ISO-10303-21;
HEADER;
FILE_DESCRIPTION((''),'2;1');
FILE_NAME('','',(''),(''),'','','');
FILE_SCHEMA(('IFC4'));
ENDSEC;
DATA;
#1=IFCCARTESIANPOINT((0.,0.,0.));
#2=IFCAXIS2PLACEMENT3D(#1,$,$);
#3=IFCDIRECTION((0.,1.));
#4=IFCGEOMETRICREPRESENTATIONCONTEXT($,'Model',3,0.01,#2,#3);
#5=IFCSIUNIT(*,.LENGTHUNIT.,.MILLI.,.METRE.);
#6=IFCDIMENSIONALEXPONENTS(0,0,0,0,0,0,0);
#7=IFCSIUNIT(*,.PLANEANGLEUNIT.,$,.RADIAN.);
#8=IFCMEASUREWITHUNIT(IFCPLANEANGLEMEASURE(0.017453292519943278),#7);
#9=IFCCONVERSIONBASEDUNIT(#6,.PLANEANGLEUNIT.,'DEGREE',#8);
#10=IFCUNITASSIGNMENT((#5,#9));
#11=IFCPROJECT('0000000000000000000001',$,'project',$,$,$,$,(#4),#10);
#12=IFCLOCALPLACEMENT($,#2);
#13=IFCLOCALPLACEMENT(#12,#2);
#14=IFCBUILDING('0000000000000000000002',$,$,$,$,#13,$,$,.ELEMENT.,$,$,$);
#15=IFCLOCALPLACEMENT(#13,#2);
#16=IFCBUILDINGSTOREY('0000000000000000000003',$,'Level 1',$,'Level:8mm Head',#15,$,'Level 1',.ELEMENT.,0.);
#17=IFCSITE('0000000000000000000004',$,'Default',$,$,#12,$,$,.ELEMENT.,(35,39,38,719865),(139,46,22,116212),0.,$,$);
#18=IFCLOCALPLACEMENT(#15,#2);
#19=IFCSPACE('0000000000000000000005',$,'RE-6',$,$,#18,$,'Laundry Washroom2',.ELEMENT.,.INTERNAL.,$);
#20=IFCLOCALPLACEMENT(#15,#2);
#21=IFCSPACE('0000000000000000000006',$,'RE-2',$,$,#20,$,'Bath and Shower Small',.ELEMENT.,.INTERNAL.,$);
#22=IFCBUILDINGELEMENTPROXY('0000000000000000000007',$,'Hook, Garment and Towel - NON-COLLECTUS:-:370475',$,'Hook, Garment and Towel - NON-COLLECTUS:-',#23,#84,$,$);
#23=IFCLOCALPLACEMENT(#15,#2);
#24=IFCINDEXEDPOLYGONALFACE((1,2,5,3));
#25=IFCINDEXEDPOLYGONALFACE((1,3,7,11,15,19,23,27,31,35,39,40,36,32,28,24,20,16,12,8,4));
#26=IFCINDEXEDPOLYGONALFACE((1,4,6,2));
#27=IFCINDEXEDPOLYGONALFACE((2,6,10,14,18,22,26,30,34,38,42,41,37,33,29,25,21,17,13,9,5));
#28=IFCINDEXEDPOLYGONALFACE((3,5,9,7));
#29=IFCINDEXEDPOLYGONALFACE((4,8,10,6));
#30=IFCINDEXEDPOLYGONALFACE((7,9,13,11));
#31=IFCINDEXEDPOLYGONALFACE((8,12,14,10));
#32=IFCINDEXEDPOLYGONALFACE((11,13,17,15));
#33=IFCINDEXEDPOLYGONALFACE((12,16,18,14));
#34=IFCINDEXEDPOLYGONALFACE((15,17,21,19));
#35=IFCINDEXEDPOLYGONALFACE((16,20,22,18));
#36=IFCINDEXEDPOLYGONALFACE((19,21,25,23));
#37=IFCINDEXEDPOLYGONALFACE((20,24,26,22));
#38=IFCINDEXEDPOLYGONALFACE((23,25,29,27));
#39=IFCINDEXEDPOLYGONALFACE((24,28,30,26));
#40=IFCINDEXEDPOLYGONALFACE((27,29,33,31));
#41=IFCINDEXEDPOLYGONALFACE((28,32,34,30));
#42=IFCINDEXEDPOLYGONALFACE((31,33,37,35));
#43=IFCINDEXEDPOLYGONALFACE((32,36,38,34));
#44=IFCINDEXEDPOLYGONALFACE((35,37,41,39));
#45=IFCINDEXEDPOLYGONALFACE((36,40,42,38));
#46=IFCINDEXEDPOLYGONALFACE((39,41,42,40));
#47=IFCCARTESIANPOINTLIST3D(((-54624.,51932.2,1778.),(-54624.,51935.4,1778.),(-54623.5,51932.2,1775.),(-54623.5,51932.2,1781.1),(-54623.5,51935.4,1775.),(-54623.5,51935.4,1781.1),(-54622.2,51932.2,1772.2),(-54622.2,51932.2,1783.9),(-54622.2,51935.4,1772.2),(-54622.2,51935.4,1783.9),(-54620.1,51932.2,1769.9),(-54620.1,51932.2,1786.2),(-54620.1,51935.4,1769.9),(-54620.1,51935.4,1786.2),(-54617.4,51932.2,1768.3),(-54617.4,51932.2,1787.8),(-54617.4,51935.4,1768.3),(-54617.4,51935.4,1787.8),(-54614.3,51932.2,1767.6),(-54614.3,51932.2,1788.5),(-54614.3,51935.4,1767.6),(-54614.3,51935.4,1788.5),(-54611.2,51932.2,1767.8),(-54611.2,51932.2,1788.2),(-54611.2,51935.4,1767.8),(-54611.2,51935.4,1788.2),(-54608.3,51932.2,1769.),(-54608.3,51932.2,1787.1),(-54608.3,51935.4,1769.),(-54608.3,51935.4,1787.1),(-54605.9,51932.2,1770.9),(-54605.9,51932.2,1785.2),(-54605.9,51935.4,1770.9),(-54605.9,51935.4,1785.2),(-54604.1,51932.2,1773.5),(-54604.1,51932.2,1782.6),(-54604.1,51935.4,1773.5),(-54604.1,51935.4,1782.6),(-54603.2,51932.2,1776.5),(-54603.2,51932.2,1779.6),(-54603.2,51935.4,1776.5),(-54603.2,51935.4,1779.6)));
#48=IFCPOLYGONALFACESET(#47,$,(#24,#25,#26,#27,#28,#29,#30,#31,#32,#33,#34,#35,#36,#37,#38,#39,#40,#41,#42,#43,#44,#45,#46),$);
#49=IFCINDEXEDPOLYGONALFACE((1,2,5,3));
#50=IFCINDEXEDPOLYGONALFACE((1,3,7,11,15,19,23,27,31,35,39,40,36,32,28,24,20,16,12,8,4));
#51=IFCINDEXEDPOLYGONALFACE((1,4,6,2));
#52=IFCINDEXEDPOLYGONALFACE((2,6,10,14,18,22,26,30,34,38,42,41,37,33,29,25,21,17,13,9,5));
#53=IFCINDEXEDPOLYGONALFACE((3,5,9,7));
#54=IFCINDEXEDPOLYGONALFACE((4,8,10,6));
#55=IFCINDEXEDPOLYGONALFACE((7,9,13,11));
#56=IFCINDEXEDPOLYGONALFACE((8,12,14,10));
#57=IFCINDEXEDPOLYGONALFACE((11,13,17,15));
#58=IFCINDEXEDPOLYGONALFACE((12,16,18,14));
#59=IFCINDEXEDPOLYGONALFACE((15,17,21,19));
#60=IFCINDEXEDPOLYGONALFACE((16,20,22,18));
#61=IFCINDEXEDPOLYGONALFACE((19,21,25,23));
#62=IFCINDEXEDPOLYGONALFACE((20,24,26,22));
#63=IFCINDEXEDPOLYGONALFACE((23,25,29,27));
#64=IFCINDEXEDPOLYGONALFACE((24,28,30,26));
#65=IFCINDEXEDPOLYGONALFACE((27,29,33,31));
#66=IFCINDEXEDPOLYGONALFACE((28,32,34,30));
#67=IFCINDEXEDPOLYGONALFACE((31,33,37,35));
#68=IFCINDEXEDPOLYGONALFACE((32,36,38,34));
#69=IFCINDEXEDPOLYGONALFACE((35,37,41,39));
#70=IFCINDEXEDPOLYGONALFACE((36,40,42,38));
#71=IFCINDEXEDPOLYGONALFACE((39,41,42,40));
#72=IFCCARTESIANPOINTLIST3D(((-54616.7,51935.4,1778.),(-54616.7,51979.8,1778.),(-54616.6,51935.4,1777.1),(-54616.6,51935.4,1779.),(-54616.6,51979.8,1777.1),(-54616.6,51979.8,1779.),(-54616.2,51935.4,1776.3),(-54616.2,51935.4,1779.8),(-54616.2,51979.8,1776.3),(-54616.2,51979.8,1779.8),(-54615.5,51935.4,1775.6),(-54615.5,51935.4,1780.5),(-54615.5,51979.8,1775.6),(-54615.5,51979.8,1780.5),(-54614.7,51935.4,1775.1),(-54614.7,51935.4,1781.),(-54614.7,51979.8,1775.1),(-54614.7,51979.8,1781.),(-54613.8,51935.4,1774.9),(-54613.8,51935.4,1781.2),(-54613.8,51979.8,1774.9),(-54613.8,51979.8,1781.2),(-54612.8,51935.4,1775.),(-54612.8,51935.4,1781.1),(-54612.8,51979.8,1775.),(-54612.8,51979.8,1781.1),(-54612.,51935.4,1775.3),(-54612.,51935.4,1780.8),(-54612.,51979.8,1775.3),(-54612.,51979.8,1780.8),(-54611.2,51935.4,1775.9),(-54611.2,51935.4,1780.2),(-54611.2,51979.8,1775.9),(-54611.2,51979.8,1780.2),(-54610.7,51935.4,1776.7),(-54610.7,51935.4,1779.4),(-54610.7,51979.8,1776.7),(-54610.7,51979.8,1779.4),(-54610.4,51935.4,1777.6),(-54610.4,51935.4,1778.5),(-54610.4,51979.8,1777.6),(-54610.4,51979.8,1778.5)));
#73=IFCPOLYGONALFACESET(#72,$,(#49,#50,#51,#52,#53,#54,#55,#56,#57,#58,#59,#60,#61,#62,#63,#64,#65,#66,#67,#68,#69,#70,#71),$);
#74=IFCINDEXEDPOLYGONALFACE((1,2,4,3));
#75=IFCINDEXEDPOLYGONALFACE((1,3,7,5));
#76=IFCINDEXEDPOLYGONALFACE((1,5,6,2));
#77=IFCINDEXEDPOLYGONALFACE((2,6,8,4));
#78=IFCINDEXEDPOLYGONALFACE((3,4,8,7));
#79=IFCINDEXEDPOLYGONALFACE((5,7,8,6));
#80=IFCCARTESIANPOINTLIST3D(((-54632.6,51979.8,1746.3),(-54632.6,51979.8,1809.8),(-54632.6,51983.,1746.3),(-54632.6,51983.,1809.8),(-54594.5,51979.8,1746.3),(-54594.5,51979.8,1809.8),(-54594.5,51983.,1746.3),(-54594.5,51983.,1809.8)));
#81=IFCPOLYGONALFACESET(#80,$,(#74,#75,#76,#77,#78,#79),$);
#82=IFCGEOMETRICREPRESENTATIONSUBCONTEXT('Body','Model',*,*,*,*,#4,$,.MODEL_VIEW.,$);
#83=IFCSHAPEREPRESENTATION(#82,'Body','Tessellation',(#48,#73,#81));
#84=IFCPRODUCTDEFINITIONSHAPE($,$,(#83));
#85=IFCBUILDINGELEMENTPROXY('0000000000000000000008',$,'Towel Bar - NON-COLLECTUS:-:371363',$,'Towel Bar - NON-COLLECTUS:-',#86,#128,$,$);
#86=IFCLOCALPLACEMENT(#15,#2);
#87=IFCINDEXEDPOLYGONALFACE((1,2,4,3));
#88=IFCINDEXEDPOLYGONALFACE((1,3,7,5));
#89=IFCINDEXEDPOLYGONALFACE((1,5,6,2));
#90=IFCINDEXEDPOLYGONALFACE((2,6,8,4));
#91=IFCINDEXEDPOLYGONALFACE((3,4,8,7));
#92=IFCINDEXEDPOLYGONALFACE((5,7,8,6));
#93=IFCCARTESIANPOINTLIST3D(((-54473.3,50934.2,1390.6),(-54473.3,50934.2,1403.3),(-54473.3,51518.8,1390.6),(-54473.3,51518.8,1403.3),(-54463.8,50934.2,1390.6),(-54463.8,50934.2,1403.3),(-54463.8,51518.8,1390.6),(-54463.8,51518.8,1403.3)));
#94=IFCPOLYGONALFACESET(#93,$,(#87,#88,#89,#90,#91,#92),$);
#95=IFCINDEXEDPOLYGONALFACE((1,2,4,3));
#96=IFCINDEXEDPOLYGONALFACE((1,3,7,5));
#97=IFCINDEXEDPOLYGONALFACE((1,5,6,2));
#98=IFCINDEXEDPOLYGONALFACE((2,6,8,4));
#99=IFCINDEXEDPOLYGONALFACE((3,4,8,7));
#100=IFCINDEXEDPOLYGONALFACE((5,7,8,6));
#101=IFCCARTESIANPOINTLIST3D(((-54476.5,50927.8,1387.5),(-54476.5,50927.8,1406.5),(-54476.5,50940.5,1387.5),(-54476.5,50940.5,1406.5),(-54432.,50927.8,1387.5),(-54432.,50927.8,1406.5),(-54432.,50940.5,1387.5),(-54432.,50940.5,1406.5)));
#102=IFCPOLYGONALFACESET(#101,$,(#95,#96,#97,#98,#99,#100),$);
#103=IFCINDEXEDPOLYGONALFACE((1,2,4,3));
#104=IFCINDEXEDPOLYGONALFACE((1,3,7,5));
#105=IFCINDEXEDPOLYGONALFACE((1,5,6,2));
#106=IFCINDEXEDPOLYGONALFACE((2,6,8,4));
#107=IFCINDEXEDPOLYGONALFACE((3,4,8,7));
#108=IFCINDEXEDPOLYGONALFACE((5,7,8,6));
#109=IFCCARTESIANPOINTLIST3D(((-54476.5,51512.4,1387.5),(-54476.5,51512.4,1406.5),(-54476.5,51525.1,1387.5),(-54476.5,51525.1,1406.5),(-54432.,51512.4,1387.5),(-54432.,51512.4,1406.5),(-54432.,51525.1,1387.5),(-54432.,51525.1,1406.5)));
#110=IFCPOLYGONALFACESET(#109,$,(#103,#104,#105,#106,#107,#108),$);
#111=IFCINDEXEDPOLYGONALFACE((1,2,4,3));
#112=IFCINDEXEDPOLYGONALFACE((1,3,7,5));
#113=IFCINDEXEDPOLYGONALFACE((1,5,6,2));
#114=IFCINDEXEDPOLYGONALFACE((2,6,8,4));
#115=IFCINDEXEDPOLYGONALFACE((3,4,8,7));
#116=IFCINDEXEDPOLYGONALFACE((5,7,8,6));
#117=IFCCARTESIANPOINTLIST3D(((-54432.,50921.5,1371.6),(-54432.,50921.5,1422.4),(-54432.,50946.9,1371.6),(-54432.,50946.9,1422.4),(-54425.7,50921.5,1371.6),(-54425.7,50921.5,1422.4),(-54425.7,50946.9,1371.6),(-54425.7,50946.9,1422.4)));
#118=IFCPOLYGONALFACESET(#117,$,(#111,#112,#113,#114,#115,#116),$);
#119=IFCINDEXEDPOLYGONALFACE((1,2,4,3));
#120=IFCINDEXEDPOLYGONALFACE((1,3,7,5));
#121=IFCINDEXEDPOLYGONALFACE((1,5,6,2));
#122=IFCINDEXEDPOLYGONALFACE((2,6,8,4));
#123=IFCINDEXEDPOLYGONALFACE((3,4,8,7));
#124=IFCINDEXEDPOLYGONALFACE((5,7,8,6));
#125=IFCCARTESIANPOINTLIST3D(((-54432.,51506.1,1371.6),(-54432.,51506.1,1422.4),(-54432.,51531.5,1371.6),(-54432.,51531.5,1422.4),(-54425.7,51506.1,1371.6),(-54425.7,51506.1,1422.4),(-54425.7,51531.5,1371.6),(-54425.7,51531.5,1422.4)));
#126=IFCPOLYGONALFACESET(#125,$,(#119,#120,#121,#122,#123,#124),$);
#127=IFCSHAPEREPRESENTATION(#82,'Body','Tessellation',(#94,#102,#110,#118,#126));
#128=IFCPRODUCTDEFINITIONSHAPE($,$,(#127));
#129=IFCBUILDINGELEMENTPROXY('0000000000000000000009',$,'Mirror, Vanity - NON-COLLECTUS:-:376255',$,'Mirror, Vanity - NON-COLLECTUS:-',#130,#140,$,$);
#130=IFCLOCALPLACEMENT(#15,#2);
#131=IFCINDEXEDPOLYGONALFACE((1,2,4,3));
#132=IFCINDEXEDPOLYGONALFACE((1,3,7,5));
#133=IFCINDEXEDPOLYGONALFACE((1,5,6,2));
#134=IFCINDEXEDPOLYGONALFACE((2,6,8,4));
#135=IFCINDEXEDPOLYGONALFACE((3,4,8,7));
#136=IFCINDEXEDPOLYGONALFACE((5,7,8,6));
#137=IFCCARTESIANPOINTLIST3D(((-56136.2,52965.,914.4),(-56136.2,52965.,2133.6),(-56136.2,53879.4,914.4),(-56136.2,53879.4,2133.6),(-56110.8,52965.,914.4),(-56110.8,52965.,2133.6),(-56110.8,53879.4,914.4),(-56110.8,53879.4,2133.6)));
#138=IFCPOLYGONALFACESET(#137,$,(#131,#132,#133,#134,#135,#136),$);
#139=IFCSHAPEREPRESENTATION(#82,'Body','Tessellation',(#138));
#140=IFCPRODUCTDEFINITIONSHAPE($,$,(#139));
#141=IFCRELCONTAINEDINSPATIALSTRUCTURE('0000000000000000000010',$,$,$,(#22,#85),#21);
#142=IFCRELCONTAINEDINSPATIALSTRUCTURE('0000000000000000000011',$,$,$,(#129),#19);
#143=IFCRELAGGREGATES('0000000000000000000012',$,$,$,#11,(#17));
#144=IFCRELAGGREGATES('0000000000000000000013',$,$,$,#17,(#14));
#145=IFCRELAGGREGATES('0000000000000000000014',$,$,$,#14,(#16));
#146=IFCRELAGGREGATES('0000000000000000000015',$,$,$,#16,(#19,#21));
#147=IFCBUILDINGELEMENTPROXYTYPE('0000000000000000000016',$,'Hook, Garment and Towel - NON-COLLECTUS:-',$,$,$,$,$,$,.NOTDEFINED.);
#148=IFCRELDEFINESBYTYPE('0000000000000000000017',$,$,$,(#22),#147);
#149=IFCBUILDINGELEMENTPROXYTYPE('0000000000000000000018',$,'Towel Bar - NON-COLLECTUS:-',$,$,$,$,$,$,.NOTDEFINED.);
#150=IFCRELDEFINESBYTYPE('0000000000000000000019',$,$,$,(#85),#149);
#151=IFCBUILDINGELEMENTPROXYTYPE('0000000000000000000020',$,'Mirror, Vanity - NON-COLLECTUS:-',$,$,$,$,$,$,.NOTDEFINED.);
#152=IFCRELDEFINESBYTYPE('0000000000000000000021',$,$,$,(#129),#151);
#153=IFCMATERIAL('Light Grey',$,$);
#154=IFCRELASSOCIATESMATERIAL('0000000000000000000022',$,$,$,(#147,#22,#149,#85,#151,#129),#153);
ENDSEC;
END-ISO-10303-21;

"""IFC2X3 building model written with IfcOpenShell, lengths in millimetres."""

from ifc_helpers import new_model, entity, si_unit, converted_unit, direction, frame, frame_2d, origin, origin_2d_with_axis, place, context, subcontext, project, spatial, rectangle, circle, extrude, source, transform, mapped, material, type_object, type_shapes, element, save


model = new_model("IFC2X3")

# Units and contexts
model_context = context("Model", 3, precision=0.01, world=origin(), true_north=direction((0.0, 1.0)))
body_context = subcontext(model_context, "Body", "Model", "MODEL_VIEW")
ifc_project = project(units=[si_unit("LENGTHUNIT", "METRE", prefix="MILLI"), converted_unit("PLANEANGLEUNIT", "DEGREE", entity("IfcPlaneAngleMeasure", 0.017453292519943278), si_unit("PLANEANGLEUNIT", "RADIAN"), dimensions=[0, 0, 0, 0, 0, 0, 0])], contexts=[model_context])

# Site, building, storey
site_placement = place(None, origin())
site = spatial("IfcSite", under=ifc_project, at=site_placement, Name="Default", CompositionType="ELEMENT", RefLatitude=(35, 39, 38, 719865), RefLongitude=(139, 46, 22, 116212), RefElevation=0.0)
building_placement = place(site_placement, origin())
building = spatial("IfcBuilding", under=site, at=building_placement, CompositionType="ELEMENT")
storey_placement = place(building_placement, origin())
storey = spatial("IfcBuildingStorey", under=building, at=storey_placement, Name="Level 1", ObjectType="Level:8mm Head", LongName="Level 1", CompositionType="ELEMENT", Elevation=0.0)

# Shared definitions
space_1_placement = place(storey_placement, origin())
space_1 = spatial("IfcSpace", under=storey, at=space_1_placement, Name="RE-6", LongName="Laundry Washroom2", CompositionType="ELEMENT", InteriorOrExteriorSpace="INTERNAL")

# Shared definitions
ifc_material_1 = material(Name="Light Grey")

# Shared definitions
space_2_placement = place(storey_placement, origin())
space_2 = spatial("IfcSpace", under=storey, at=space_2_placement, Name="RE-2", LongName="Bath and Shower Small", CompositionType="ELEMENT", InteriorOrExteriorSpace="INTERNAL")

# Building element proxies
building_element_proxy_type_1 = type_object("IfcBuildingElementProxyType", Name="Hook, Garment and Towel - NON-COLLECTUS:-", PredefinedType="NOTDEFINED", material=ifc_material_1)
shared_shape_1 = source(origin(), body_context, "Body", "SweptSolid", [
    extrude(circle(Radius=10.5, at=frame_2d((0.0, 0.0), x_axis=(1.0, 0.0))), frame((19.1, -50.8, 31.8), z_axis=(0.0, 1.0, 0.0), x_axis=(-1.0, 0.0, 0.0)), (0.0, 0.0, 1.0), 3.2),
    extrude(circle(Radius=3.2, at=frame_2d((0.0, 0.0), x_axis=(1.0, 0.0))), frame((19.1, -47.6, 31.8), z_axis=(0.0, 1.0, 0.0), x_axis=(-1.0, 0.0, 0.0)), (0.0, 0.0, 1.0), 44.5),
    extrude(rectangle(XDim=3.2, YDim=38.1, at=origin_2d_with_axis()), frame((19.1, -1.6, 0.0), z_axis=(0.0, 0.0, 1.0), x_axis=(0.0, 1.0, 0.0)), (0.0, 0.0, 1.0), 63.5),
])
type_shapes(building_element_proxy_type_1, [shared_shape_1])
proxy_1_placement = place(space_2_placement, frame((-54632.6, 51983.0, 1746.3)))
element("IfcBuildingElementProxy", 1, at=proxy_1_placement, inside=space_2, type_object=building_element_proxy_type_1, material=ifc_material_1, Name="Hook, Garment and Towel - NON-COLLECTUS:-:370475", ObjectType="Hook, Garment and Towel - NON-COLLECTUS:-", context=body_context, shape_type="MappedRepresentation", body=[
    mapped(shared_shape_1, transform((0.0, 0.0, 0.0), scale=1.0)),
])
building_element_proxy_type_2 = type_object("IfcBuildingElementProxyType", Name="Towel Bar - NON-COLLECTUS:-", PredefinedType="NOTDEFINED", material=ifc_material_1)
shared_shape_2 = source(origin(), body_context, "Body", "SweptSolid", [
    extrude(rectangle(XDim=584.6, YDim=9.5, at=origin_2d_with_axis()), frame((0.0, -42.9, 19.1), z_axis=(0.0, 0.0, 1.0), x_axis=(-1.0, 0.0, 0.0)), (0.0, 0.0, 1.0), 12.7),
    extrude(rectangle(XDim=44.5, YDim=12.7, at=frame_2d((0.0, 0.0), x_axis=(1.0, 0.0))), frame((292.3, -28.6, 15.9), z_axis=(0.0, 0.0, 1.0), x_axis=(0.0, -1.0, 0.0)), (0.0, 0.0, 1.0), 19.1),
    extrude(rectangle(XDim=44.5, YDim=12.7, at=origin_2d_with_axis()), frame((-292.3, -28.6, 15.9), z_axis=(0.0, 0.0, 1.0), x_axis=(0.0, -1.0, 0.0)), (0.0, 0.0, 1.0), 19.1),
    extrude(rectangle(XDim=6.3, YDim=25.4, at=frame_2d((0.0, 0.0), x_axis=(1.0, 0.0))), frame((292.3, -3.2, 0.0), z_axis=(0.0, 0.0, 1.0), x_axis=(0.0, -1.0, 0.0)), (0.0, 0.0, 1.0), 50.8),
    extrude(rectangle(XDim=6.3, YDim=25.4, at=frame_2d((0.0, 0.0), x_axis=(1.0, 0.0))), frame((-292.3, -3.2, 0.0), z_axis=(0.0, 0.0, 1.0), x_axis=(0.0, -1.0, 0.0)), (0.0, 0.0, 1.0), 50.8),
])
type_shapes(building_element_proxy_type_2, [shared_shape_2])
proxy_2_placement = place(space_2_placement, frame((-54425.7, 51226.5, 1371.6), z_axis=(0.0, 0.0, 1.0), x_axis=(0.000001, -1.0, 0.0)))
element("IfcBuildingElementProxy", 2, at=proxy_2_placement, inside=space_2, type_object=building_element_proxy_type_2, material=ifc_material_1, Name="Towel Bar - NON-COLLECTUS:-:371363", ObjectType="Towel Bar - NON-COLLECTUS:-", context=body_context, shape_type="MappedRepresentation", body=[
    mapped(shared_shape_2, transform((0.0, 0.0, 0.0), scale=1.0)),
])
building_element_proxy_type_3 = type_object("IfcBuildingElementProxyType", Name="Mirror, Vanity - NON-COLLECTUS:-", PredefinedType="NOTDEFINED", material=ifc_material_1)
shared_shape_3 = source(origin(), body_context, "Body", "SweptSolid", [
    extrude(rectangle(XDim=914.4, YDim=25.4, at=origin_2d_with_axis()), frame((457.2, -12.7, 0.0), z_axis=(0.0, 0.0, 1.0), x_axis=(-1.0, 0.0, 0.0)), (0.0, 0.0, 1.0), 1219.2),
])
type_shapes(building_element_proxy_type_3, [shared_shape_3])
proxy_3_placement = place(space_1_placement, frame((-56136.2, 52965.0, 914.4), z_axis=(0.0, 0.0, 1.0), x_axis=(-0.000004, 1.0, 0.0)))
element("IfcBuildingElementProxy", 3, at=proxy_3_placement, inside=space_1, type_object=building_element_proxy_type_3, material=ifc_material_1, Name="Mirror, Vanity - NON-COLLECTUS:-:376255", ObjectType="Mirror, Vanity - NON-COLLECTUS:-", context=body_context, shape_type="MappedRepresentation", body=[
    mapped(shared_shape_3, transform((0.0, 0.0, 0.0), scale=1.0)),
])

save(model, "model.ifc")
